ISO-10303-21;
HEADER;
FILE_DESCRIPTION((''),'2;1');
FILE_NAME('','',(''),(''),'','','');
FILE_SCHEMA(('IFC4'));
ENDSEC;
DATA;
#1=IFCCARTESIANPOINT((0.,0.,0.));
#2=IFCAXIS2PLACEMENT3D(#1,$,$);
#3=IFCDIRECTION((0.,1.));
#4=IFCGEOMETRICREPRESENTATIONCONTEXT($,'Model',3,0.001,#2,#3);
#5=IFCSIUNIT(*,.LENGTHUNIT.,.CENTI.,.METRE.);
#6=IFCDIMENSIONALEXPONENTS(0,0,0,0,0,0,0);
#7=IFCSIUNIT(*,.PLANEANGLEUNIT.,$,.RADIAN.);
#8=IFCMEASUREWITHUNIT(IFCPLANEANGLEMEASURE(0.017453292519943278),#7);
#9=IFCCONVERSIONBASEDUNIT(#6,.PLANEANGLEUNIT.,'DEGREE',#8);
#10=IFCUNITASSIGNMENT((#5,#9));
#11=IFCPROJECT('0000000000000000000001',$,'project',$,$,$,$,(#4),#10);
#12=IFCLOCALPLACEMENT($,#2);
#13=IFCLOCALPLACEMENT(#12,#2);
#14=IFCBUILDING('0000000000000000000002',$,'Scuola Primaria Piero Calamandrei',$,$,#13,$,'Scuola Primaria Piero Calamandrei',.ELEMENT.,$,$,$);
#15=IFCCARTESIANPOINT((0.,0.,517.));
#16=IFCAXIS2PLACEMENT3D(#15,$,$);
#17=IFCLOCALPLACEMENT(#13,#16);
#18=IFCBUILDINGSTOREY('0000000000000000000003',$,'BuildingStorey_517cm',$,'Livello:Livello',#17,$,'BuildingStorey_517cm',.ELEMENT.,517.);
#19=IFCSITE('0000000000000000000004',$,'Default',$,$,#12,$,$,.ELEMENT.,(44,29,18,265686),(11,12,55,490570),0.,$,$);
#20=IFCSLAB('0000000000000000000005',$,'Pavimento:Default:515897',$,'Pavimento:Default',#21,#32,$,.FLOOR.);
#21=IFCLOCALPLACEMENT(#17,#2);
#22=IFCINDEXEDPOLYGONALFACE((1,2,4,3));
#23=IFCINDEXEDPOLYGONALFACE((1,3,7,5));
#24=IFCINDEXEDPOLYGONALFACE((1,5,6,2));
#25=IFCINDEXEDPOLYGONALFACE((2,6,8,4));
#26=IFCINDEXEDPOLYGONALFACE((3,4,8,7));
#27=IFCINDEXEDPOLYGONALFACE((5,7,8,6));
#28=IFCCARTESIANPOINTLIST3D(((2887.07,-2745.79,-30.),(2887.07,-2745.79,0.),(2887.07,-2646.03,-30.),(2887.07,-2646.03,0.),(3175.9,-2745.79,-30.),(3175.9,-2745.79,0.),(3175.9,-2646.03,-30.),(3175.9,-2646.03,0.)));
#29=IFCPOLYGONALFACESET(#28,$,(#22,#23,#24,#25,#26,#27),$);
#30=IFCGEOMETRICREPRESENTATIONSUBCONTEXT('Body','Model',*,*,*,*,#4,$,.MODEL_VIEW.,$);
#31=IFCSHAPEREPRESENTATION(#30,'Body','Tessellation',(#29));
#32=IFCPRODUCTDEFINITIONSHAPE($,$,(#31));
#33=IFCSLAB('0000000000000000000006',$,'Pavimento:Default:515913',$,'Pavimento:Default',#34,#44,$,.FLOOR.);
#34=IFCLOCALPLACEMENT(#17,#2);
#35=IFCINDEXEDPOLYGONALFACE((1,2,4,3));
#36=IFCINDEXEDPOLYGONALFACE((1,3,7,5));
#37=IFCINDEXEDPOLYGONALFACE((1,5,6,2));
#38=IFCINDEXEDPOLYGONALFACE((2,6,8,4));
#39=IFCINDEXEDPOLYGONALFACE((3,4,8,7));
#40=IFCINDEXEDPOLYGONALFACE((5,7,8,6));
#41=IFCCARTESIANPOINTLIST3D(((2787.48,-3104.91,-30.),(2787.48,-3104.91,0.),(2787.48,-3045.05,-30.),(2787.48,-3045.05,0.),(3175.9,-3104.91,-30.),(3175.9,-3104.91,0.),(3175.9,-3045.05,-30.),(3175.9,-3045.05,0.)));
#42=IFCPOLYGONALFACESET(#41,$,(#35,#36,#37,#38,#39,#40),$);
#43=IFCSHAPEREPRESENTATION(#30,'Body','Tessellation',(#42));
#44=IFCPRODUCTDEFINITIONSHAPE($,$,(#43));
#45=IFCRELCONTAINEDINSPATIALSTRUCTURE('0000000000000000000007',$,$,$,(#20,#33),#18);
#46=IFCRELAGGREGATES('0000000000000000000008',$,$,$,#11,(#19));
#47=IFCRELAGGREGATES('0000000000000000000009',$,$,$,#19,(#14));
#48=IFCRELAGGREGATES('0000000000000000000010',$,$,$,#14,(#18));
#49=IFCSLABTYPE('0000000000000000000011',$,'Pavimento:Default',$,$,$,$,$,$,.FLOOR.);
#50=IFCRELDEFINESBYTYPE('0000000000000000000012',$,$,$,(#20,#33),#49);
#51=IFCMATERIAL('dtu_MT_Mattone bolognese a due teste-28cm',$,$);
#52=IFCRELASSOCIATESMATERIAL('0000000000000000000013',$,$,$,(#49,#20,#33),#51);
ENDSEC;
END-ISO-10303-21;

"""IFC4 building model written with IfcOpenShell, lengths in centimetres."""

from ifc_helpers import new_model, entity, si_unit, converted_unit, direction, frame, origin, place, context, subcontext, project, spatial, indexed_curve, outline, extrude, material, type_object, element, save


model = new_model("IFC4")

# Units and contexts
model_context = context("Model", 3, precision=0.001, world=origin(), true_north=direction((0.0, 1.0)))
body_context = subcontext(model_context, "Body", "Model", "MODEL_VIEW")
ifc_project = project(units=[si_unit("LENGTHUNIT", "METRE", prefix="CENTI"), converted_unit("PLANEANGLEUNIT", "DEGREE", entity("IfcPlaneAngleMeasure", 0.017453292519943278), si_unit("PLANEANGLEUNIT", "RADIAN"), dimensions=[0, 0, 0, 0, 0, 0, 0])], contexts=[model_context])

# Site, building, storey
site_placement = place(None, origin())
site = spatial("IfcSite", under=ifc_project, at=site_placement, Name="Default", CompositionType="ELEMENT", RefLatitude=(44, 29, 18, 265686), RefLongitude=(11, 12, 55, 490570), RefElevation=0.0)
building_placement = place(site_placement, origin())
building = spatial("IfcBuilding", under=site, at=building_placement, Name="Scuola Primaria Piero Calamandrei", LongName="Scuola Primaria Piero Calamandrei", CompositionType="ELEMENT")
storey_placement = place(building_placement, frame((0.0, 0.0, 517.0)))
storey = spatial("IfcBuildingStorey", under=building, at=storey_placement, Name="BuildingStorey_517cm", ObjectType="Livello:Livello", LongName="BuildingStorey_517cm", CompositionType="ELEMENT", Elevation=517.0)

# Slabs
ifc_material_1 = material(Name="dtu_MT_Mattone bolognese a due teste-28cm")
slab_type_1 = type_object("IfcSlabType", Name="Pavimento:Default", PredefinedType="FLOOR", material=ifc_material_1)
slab_1_placement = place(storey_placement, origin())
element("IfcSlab", 1, at=slab_1_placement, inside=storey, type_object=slab_type_1, material=ifc_material_1, Name="Pavimento:Default:515897", ObjectType="Pavimento:Default", PredefinedType="FLOOR", context=body_context, shape_type="SweptSolid", body=[
    extrude(outline(indexed_curve([(-49.88, -144.41), (49.88, -144.41), (49.88, 144.41), (-49.88, 144.41), (-49.88, -144.41)], self_intersect=False)), frame((3031.49, -2695.91, 0.0), z_axis=(0.0, 0.0, -1.0), x_axis=(0.0, 1.0, 0.0)), (0.0, 0.0, 1.0), 30.0),
])
slab_2_placement = place(storey_placement, origin())
element("IfcSlab", 2, at=slab_2_placement, inside=storey, type_object=slab_type_1, material=ifc_material_1, Name="Pavimento:Default:515913", ObjectType="Pavimento:Default", PredefinedType="FLOOR", context=body_context, shape_type="SweptSolid", body=[
    extrude(outline(indexed_curve([(-29.93, -194.21), (29.93, -194.21), (29.93, 194.21), (-29.93, 194.21), (-29.93, -194.21)], self_intersect=False)), frame((2981.69, -3074.98, 0.0), z_axis=(0.0, 0.0, -1.0), x_axis=(0.0, 1.0, 0.0)), (0.0, 0.0, 1.0), 30.0),
])

save(model, "model.ifc")
